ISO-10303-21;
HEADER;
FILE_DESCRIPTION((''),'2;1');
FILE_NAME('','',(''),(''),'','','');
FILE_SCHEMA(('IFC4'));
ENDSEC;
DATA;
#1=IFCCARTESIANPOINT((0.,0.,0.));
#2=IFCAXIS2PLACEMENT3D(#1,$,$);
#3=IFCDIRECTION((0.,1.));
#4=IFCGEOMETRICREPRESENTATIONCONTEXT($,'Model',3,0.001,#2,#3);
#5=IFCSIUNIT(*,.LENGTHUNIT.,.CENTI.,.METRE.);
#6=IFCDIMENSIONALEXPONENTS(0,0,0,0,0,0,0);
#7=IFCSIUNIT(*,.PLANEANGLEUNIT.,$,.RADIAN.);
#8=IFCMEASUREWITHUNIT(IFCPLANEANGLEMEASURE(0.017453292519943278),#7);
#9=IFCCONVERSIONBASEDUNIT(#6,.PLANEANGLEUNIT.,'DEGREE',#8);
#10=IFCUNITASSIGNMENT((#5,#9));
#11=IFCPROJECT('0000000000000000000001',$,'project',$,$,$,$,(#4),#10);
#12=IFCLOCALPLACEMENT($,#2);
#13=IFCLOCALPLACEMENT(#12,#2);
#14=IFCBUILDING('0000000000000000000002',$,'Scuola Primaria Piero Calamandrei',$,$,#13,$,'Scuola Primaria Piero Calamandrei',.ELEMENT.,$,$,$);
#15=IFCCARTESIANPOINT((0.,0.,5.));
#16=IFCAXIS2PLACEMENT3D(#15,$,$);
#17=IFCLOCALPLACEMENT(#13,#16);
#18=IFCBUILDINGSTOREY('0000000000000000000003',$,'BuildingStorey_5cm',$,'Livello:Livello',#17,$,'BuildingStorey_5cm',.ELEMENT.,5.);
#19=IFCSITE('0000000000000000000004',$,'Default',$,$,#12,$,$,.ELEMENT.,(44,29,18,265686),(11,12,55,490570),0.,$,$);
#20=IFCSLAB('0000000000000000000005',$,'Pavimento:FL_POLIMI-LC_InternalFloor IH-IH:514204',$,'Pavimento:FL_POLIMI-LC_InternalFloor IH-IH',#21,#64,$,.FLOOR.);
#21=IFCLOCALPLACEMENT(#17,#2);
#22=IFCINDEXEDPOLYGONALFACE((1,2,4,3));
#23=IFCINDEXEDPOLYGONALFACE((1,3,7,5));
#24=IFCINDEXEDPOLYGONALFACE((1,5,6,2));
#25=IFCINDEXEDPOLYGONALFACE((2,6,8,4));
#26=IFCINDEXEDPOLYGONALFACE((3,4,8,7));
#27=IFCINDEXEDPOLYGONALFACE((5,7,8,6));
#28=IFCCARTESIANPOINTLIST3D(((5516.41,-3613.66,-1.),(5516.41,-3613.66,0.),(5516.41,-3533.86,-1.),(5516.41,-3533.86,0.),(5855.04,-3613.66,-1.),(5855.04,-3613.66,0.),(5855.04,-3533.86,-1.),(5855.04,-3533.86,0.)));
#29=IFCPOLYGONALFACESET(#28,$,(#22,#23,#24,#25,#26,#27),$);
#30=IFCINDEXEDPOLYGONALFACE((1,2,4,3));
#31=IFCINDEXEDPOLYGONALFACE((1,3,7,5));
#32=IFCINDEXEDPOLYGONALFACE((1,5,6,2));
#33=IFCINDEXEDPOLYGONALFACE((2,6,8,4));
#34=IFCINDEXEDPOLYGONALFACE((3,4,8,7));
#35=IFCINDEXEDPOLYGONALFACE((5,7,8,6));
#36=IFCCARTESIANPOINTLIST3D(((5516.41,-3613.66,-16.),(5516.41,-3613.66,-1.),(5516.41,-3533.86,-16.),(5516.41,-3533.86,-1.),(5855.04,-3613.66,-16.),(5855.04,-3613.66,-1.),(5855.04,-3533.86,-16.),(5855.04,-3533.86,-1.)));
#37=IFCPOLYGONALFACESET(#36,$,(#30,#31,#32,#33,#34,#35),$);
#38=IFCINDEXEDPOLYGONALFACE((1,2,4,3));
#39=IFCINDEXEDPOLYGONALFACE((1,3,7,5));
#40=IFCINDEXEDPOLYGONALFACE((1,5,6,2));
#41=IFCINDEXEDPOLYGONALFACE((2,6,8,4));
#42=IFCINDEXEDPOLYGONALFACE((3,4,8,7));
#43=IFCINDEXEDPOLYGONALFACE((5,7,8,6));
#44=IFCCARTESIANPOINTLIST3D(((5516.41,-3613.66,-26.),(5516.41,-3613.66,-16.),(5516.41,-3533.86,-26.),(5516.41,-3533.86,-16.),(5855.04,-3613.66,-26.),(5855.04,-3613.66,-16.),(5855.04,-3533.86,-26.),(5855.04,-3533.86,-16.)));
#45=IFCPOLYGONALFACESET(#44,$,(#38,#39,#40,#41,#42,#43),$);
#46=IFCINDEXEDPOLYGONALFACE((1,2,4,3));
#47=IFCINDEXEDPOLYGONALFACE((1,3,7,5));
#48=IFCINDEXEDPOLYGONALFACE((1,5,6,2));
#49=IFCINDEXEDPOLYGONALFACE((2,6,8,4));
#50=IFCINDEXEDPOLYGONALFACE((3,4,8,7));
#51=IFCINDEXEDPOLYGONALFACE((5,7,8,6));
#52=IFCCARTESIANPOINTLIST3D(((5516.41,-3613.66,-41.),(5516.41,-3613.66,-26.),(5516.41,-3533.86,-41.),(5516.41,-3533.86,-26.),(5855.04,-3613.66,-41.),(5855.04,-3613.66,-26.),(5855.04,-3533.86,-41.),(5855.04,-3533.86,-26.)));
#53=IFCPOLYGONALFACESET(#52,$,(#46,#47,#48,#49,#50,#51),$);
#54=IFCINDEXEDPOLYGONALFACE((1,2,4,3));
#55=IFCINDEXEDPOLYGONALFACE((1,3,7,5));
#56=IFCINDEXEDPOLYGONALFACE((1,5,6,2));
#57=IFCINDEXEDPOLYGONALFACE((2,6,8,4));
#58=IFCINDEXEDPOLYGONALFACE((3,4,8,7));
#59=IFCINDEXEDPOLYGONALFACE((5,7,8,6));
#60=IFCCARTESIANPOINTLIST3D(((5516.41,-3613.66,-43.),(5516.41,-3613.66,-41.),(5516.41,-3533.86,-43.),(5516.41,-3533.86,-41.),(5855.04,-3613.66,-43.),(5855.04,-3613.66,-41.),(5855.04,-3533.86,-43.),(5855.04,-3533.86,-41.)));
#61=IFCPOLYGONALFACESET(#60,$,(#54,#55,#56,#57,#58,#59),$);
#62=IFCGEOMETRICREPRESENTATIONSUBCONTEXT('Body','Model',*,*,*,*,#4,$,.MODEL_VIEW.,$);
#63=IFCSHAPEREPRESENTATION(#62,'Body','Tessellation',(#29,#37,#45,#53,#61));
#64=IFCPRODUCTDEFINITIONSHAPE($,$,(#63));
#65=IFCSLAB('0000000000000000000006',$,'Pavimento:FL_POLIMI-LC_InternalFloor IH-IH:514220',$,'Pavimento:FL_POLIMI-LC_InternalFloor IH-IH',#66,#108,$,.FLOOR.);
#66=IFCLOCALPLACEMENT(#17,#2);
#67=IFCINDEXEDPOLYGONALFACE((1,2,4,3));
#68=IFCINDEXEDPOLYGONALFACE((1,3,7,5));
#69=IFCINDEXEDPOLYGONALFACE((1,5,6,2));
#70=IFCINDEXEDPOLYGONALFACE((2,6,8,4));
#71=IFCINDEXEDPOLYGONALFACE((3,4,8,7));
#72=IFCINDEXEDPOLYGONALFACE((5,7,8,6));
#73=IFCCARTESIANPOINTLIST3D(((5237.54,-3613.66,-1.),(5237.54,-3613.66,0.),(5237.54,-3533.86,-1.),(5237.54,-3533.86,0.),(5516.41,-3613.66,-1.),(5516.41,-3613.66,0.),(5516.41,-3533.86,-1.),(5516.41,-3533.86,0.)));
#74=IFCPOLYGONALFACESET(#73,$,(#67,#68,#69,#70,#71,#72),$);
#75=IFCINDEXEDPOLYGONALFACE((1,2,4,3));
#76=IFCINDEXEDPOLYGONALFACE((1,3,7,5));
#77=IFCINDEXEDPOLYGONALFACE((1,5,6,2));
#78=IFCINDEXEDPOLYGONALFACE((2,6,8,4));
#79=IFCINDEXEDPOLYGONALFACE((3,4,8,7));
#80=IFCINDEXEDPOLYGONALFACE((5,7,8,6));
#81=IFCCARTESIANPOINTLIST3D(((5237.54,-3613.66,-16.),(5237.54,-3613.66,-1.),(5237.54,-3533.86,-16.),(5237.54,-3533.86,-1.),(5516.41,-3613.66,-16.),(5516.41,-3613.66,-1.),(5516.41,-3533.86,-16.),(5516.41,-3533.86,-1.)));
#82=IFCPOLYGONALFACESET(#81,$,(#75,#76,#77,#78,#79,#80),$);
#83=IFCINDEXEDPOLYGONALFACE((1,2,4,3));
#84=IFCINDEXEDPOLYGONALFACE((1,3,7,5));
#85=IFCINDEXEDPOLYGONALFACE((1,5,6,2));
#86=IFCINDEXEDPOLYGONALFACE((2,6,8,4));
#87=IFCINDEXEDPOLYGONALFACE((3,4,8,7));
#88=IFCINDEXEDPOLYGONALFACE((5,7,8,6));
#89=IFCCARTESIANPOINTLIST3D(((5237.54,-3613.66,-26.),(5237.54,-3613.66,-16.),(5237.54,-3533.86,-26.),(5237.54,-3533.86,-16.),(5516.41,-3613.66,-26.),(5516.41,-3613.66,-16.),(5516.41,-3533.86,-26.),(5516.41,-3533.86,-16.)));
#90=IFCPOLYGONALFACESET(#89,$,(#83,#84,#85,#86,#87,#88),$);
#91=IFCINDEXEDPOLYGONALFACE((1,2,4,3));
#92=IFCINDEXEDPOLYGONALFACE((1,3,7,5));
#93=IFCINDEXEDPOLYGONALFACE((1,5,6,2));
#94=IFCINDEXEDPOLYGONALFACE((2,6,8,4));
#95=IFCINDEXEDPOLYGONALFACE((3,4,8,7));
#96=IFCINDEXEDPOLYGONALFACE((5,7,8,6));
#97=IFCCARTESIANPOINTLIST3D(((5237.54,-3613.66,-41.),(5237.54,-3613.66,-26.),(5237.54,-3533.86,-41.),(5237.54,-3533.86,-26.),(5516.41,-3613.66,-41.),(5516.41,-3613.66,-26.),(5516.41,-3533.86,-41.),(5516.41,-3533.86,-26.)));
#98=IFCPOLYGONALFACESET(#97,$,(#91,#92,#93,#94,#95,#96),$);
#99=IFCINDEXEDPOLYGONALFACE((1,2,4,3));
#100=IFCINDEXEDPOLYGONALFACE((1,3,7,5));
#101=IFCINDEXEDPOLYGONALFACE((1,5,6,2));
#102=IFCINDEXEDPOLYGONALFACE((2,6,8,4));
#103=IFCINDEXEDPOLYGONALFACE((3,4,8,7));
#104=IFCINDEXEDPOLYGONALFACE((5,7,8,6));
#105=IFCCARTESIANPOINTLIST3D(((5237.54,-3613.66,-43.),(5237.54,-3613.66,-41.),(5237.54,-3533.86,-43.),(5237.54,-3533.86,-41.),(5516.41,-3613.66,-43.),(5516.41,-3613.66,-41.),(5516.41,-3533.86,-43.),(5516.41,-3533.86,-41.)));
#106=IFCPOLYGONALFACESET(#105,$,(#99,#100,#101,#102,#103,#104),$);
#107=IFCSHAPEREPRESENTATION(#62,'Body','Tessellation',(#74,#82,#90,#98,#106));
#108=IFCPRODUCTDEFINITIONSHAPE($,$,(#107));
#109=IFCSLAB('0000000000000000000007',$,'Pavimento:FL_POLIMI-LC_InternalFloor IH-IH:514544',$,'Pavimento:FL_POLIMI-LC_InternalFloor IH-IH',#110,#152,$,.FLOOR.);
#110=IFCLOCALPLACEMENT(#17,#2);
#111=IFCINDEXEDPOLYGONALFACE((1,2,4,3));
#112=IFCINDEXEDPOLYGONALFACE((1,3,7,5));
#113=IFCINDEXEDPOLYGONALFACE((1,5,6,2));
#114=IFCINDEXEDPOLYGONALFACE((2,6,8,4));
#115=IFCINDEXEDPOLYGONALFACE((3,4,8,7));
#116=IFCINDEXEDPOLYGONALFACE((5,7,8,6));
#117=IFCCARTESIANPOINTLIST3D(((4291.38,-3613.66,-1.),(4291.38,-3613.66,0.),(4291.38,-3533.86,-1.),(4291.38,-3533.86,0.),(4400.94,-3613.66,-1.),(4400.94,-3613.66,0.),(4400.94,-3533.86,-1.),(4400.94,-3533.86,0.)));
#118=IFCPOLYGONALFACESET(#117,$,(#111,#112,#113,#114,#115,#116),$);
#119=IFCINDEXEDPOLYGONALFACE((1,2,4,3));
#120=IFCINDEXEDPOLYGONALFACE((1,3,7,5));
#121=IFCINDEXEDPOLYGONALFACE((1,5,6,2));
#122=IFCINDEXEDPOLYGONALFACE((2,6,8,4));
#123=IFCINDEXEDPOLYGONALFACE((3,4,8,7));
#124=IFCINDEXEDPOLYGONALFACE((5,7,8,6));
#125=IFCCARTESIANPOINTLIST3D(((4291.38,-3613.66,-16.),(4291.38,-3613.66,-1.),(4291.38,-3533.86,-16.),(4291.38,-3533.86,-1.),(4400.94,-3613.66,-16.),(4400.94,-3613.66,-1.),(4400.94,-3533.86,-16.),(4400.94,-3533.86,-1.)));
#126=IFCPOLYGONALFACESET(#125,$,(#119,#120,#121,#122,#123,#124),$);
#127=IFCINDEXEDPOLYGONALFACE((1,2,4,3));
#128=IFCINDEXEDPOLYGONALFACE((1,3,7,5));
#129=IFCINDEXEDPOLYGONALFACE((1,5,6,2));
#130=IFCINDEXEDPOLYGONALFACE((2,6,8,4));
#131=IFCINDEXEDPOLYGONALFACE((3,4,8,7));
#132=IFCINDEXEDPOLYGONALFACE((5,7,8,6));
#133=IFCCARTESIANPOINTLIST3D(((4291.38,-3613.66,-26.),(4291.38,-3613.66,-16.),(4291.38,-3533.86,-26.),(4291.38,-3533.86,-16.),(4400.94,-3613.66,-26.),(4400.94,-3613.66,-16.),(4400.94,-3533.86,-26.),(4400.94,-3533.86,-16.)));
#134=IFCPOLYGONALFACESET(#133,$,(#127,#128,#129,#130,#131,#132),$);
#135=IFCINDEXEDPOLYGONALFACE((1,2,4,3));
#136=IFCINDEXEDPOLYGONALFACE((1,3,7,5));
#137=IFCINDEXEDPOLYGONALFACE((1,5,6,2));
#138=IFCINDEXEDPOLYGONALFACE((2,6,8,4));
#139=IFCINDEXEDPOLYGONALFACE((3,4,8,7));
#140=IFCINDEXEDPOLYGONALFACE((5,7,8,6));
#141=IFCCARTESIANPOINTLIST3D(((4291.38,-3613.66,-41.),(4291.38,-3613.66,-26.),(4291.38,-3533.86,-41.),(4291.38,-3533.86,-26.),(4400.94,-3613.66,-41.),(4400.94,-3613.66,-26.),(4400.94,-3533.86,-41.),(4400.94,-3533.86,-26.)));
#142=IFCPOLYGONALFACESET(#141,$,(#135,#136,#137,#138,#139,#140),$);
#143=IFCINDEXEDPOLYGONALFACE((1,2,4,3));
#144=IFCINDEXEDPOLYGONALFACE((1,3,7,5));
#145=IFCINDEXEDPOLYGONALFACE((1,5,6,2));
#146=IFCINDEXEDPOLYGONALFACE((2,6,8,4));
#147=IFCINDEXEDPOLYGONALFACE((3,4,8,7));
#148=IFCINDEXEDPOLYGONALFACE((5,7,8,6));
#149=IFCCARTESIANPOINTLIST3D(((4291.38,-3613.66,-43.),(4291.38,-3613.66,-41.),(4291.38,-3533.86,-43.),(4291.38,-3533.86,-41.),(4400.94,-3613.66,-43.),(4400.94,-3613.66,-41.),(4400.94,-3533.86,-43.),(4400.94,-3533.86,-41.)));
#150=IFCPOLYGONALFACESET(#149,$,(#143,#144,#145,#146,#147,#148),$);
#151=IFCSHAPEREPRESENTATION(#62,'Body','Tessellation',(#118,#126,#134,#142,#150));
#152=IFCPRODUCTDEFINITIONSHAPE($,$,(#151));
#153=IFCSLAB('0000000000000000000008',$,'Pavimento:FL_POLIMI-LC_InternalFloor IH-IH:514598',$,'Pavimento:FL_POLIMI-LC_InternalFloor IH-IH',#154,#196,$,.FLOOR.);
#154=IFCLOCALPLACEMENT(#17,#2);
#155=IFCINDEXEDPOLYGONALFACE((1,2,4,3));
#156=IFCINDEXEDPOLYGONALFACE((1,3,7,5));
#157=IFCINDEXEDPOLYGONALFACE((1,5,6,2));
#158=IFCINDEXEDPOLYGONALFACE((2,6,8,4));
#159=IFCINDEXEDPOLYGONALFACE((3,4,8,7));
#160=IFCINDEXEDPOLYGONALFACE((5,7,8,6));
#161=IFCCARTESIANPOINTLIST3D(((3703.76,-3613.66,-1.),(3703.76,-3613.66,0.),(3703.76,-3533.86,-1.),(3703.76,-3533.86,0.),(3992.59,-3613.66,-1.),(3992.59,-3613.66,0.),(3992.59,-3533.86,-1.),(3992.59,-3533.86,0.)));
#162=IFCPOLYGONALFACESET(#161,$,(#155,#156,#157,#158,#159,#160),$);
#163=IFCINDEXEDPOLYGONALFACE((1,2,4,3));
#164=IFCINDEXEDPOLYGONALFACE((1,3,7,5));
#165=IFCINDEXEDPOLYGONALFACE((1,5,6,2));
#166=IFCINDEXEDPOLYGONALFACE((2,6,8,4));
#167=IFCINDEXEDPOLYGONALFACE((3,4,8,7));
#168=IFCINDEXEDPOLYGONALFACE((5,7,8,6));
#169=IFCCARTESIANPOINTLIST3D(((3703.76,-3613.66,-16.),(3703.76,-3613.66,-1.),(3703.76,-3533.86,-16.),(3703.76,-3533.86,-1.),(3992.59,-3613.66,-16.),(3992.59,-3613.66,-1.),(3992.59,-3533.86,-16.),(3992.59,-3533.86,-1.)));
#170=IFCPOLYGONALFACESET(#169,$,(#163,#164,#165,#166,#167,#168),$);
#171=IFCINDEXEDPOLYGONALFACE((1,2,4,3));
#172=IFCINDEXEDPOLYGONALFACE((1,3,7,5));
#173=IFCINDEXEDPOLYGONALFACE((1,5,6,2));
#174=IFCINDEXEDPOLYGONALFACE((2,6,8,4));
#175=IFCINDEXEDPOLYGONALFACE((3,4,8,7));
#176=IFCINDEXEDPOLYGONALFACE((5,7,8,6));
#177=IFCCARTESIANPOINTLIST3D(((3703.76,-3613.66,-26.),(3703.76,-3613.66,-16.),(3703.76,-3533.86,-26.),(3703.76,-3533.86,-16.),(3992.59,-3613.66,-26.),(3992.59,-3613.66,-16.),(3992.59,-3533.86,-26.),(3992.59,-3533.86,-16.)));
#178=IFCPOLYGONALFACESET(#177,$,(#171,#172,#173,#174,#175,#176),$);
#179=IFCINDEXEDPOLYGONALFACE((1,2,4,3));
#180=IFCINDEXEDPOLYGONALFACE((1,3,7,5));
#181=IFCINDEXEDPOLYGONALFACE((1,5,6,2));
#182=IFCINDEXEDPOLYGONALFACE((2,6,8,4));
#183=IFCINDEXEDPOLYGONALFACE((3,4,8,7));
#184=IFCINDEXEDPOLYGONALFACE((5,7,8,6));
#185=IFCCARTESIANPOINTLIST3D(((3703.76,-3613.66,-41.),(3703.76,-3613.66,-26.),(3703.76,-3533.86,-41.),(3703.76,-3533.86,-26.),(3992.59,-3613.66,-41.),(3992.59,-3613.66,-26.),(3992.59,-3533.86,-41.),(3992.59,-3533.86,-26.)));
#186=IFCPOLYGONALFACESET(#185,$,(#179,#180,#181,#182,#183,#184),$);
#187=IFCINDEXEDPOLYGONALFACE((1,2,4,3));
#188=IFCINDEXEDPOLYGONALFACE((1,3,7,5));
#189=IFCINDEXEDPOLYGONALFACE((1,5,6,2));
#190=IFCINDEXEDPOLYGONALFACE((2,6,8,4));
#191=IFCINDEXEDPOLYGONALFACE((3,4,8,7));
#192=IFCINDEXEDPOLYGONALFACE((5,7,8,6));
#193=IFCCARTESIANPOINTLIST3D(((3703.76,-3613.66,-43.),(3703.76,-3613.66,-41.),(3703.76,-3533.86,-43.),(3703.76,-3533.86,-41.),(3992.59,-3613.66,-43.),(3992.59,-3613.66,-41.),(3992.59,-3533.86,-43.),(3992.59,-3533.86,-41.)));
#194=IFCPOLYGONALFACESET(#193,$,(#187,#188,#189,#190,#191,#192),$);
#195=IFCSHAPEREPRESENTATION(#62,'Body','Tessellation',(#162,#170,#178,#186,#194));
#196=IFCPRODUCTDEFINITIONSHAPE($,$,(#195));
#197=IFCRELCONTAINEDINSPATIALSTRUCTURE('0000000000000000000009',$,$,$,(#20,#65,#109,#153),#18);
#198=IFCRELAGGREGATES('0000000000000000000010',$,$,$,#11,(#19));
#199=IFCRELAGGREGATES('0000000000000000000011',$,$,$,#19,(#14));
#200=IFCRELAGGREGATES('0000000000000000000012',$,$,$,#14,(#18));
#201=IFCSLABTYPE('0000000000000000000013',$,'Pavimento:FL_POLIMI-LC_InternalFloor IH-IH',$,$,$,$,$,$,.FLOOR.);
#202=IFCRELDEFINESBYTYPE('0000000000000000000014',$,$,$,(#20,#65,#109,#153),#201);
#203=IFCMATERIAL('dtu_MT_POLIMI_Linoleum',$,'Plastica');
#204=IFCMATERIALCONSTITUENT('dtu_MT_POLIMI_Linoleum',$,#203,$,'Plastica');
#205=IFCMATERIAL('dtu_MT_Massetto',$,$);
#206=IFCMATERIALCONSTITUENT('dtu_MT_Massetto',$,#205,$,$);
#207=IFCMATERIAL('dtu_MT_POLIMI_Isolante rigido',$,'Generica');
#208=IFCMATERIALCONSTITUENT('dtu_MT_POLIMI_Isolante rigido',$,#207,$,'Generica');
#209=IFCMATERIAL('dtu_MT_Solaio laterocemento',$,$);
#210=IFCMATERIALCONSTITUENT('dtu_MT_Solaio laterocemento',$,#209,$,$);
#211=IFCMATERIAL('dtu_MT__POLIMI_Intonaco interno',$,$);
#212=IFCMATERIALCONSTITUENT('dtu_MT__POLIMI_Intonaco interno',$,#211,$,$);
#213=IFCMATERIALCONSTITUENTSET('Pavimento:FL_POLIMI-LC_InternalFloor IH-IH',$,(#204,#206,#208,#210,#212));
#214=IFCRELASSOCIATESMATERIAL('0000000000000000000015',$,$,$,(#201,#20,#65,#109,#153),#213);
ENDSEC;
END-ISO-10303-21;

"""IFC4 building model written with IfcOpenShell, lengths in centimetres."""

from ifc_helpers import new_model, entity, si_unit, converted_unit, direction, frame, origin, place, context, subcontext, project, spatial, indexed_curve, outline, extrude, material, constituent, constituent_set, type_object, element, save


model = new_model("IFC4")

# Units and contexts
model_context = context("Model", 3, precision=0.001, world=origin(), true_north=direction((0.0, 1.0)))
body_context = subcontext(model_context, "Body", "Model", "MODEL_VIEW")
ifc_project = project(units=[si_unit("LENGTHUNIT", "METRE", prefix="CENTI"), converted_unit("PLANEANGLEUNIT", "DEGREE", entity("IfcPlaneAngleMeasure", 0.017453292519943278), si_unit("PLANEANGLEUNIT", "RADIAN"), dimensions=[0, 0, 0, 0, 0, 0, 0])], contexts=[model_context])

# Site, building, storey
site_placement = place(None, origin())
site = spatial("IfcSite", under=ifc_project, at=site_placement, Name="Default", CompositionType="ELEMENT", RefLatitude=(44, 29, 18, 265686), RefLongitude=(11, 12, 55, 490570), RefElevation=0.0)
building_placement = place(site_placement, origin())
building = spatial("IfcBuilding", under=site, at=building_placement, Name="Scuola Primaria Piero Calamandrei", LongName="Scuola Primaria Piero Calamandrei", CompositionType="ELEMENT")
storey_placement = place(building_placement, frame((0.0, 0.0, 5.0)))
storey = spatial("IfcBuildingStorey", under=building, at=storey_placement, Name="BuildingStorey_5cm", ObjectType="Livello:Livello", LongName="BuildingStorey_5cm", CompositionType="ELEMENT", Elevation=5.0)

# Slabs
ifc_material_1 = material(Name="dtu_MT_POLIMI_Linoleum", Category="Plastica")
ifc_constituent_1 = constituent(ifc_material_1, Name="dtu_MT_POLIMI_Linoleum", Category="Plastica")
ifc_material_2 = material(Name="dtu_MT_Massetto")
ifc_constituent_2 = constituent(ifc_material_2, Name="dtu_MT_Massetto")
ifc_material_3 = material(Name="dtu_MT_POLIMI_Isolante rigido", Category="Generica")
ifc_constituent_3 = constituent(ifc_material_3, Name="dtu_MT_POLIMI_Isolante rigido", Category="Generica")
ifc_material_4 = material(Name="dtu_MT_Solaio laterocemento")
ifc_constituent_4 = constituent(ifc_material_4, Name="dtu_MT_Solaio laterocemento")
ifc_material_5 = material(Name="dtu_MT__POLIMI_Intonaco interno")
ifc_constituent_5 = constituent(ifc_material_5, Name="dtu_MT__POLIMI_Intonaco interno")
ifc_constituent_set_1 = constituent_set(constituents=[ifc_constituent_1, ifc_constituent_2, ifc_constituent_3, ifc_constituent_4, ifc_constituent_5], Name="Pavimento:FL_POLIMI-LC_InternalFloor IH-IH")
slab_type_1 = type_object("IfcSlabType", Name="Pavimento:FL_POLIMI-LC_InternalFloor IH-IH", PredefinedType="FLOOR", material=ifc_constituent_set_1)
slab_1_placement = place(storey_placement, origin())
element("IfcSlab", 1, at=slab_1_placement, inside=storey, type_object=slab_type_1, material=ifc_constituent_set_1, Name="Pavimento:FL_POLIMI-LC_InternalFloor IH-IH:514204", ObjectType="Pavimento:FL_POLIMI-LC_InternalFloor IH-IH", PredefinedType="FLOOR", context=body_context, shape_type="SweptSolid", body=[
    extrude(outline(indexed_curve([(-39.9, -169.31), (39.9, -169.31), (39.9, 169.31), (-39.9, 169.31), (-39.9, -169.31)], self_intersect=False)), frame((5685.73, -3573.76, -1.0), z_axis=(0.0, 0.0, 1.0), x_axis=(0.0, -1.0, 0.0)), (0.0, 0.0, 1.0), 1.0),
    extrude(outline(indexed_curve([(-39.9, -169.31), (39.9, -169.31), (39.9, 169.31), (-39.9, 169.31), (-39.9, -169.31)], self_intersect=False)), frame((5685.73, -3573.76, -16.0), z_axis=(0.0, 0.0, 1.0), x_axis=(0.0, -1.0, 0.0)), (0.0, 0.0, 1.0), 15.0),
    extrude(outline(indexed_curve([(-39.9, -169.31), (39.9, -169.31), (39.9, 169.31), (-39.9, 169.31), (-39.9, -169.31)], self_intersect=False)), frame((5685.73, -3573.76, -26.0), z_axis=(0.0, 0.0, 1.0), x_axis=(0.0, -1.0, 0.0)), (0.0, 0.0, 1.0), 10.0),
    extrude(outline(indexed_curve([(-39.9, -169.31), (39.9, -169.31), (39.9, 169.31), (-39.9, 169.31), (-39.9, -169.31)], self_intersect=False)), frame((5685.73, -3573.76, -41.0), z_axis=(0.0, 0.0, 1.0), x_axis=(0.0, -1.0, 0.0)), (0.0, 0.0, 1.0), 15.0),
    extrude(outline(indexed_curve([(-39.9, -169.31), (39.9, -169.31), (39.9, 169.31), (-39.9, 169.31), (-39.9, -169.31)], self_intersect=False)), frame((5685.73, -3573.76, -43.0), z_axis=(0.0, 0.0, 1.0), x_axis=(0.0, -1.0, 0.0)), (0.0, 0.0, 1.0), 2.0),
])
slab_2_placement = place(storey_placement, origin())
element("IfcSlab", 2, at=slab_2_placement, inside=storey, type_object=slab_type_1, material=ifc_constituent_set_1, Name="Pavimento:FL_POLIMI-LC_InternalFloor IH-IH:514220", ObjectType="Pavimento:FL_POLIMI-LC_InternalFloor IH-IH", PredefinedType="FLOOR", context=body_context, shape_type="SweptSolid", body=[
    extrude(outline(indexed_curve([(-139.43, -39.9), (139.43, -39.9), (139.43, 39.9), (-139.43, 39.9), (-139.43, -39.9)], self_intersect=False)), frame((5376.98, -3573.76, -1.0), z_axis=(0.0, 0.0, 1.0), x_axis=(-1.0, 0.0, 0.0)), (0.0, 0.0, 1.0), 1.0),
    extrude(outline(indexed_curve([(-139.43, -39.9), (139.43, -39.9), (139.43, 39.9), (-139.43, 39.9), (-139.43, -39.9)], self_intersect=False)), frame((5376.98, -3573.76, -16.0), z_axis=(0.0, 0.0, 1.0), x_axis=(-1.0, 0.0, 0.0)), (0.0, 0.0, 1.0), 15.0),
    extrude(outline(indexed_curve([(-139.43, -39.9), (139.43, -39.9), (139.43, 39.9), (-139.43, 39.9), (-139.43, -39.9)], self_intersect=False)), frame((5376.98, -3573.76, -26.0), z_axis=(0.0, 0.0, 1.0), x_axis=(-1.0, 0.0, 0.0)), (0.0, 0.0, 1.0), 10.0),
    extrude(outline(indexed_curve([(-139.43, -39.9), (139.43, -39.9), (139.43, 39.9), (-139.43, 39.9), (-139.43, -39.9)], self_intersect=False)), frame((5376.98, -3573.76, -41.0), z_axis=(0.0, 0.0, 1.0), x_axis=(-1.0, 0.0, 0.0)), (0.0, 0.0, 1.0), 15.0),
    extrude(outline(indexed_curve([(-139.43, -39.9), (139.43, -39.9), (139.43, 39.9), (-139.43, 39.9), (-139.43, -39.9)], self_intersect=False)), frame((5376.98, -3573.76, -43.0), z_axis=(0.0, 0.0, 1.0), x_axis=(-1.0, 0.0, 0.0)), (0.0, 0.0, 1.0), 2.0),
])
slab_3_placement = place(storey_placement, origin())
element("IfcSlab", 3, at=slab_3_placement, inside=storey, type_object=slab_type_1, material=ifc_constituent_set_1, Name="Pavimento:FL_POLIMI-LC_InternalFloor IH-IH:514544", ObjectType="Pavimento:FL_POLIMI-LC_InternalFloor IH-IH", PredefinedType="FLOOR", context=body_context, shape_type="SweptSolid", body=[
    extrude(outline(indexed_curve([(-39.9, -54.78), (39.9, -54.78), (39.9, 54.78), (-39.9, 54.78), (-39.9, -54.78)], self_intersect=False)), frame((4346.16, -3573.76, -1.0), z_axis=(0.0, 0.0, 1.0), x_axis=(0.0, -1.0, 0.0)), (0.0, 0.0, 1.0), 1.0),
    extrude(outline(indexed_curve([(-39.9, -54.78), (39.9, -54.78), (39.9, 54.78), (-39.9, 54.78), (-39.9, -54.78)], self_intersect=False)), frame((4346.16, -3573.76, -16.0), z_axis=(0.0, 0.0, 1.0), x_axis=(0.0, -1.0, 0.0)), (0.0, 0.0, 1.0), 15.0),
    extrude(outline(indexed_curve([(-39.9, -54.78), (39.9, -54.78), (39.9, 54.78), (-39.9, 54.78), (-39.9, -54.78)], self_intersect=False)), frame((4346.16, -3573.76, -26.0), z_axis=(0.0, 0.0, 1.0), x_axis=(0.0, -1.0, 0.0)), (0.0, 0.0, 1.0), 10.0),
    extrude(outline(indexed_curve([(-39.9, -54.78), (39.9, -54.78), (39.9, 54.78), (-39.9, 54.78), (-39.9, -54.78)], self_intersect=False)), frame((4346.16, -3573.76, -41.0), z_axis=(0.0, 0.0, 1.0), x_axis=(0.0, -1.0, 0.0)), (0.0, 0.0, 1.0), 15.0),
    extrude(outline(indexed_curve([(-39.9, -54.78), (39.9, -54.78), (39.9, 54.78), (-39.9, 54.78), (-39.9, -54.78)], self_intersect=False)), frame((4346.16, -3573.76, -43.0), z_axis=(0.0, 0.0, 1.0), x_axis=(0.0, -1.0, 0.0)), (0.0, 0.0, 1.0), 2.0),
])
slab_4_placement = place(storey_placement, origin())
element("IfcSlab", 4, at=slab_4_placement, inside=storey, type_object=slab_type_1, material=ifc_constituent_set_1, Name="Pavimento:FL_POLIMI-LC_InternalFloor IH-IH:514598", ObjectType="Pavimento:FL_POLIMI-LC_InternalFloor IH-IH", PredefinedType="FLOOR", context=body_context, shape_type="SweptSolid", body=[
    extrude(outline(indexed_curve([(-39.9, -144.41), (39.9, -144.41), (39.9, 144.41), (-39.9, 144.41), (-39.9, -144.41)], self_intersect=False)), frame((3848.18, -3573.76, -1.0), z_axis=(0.0, 0.0, 1.0), x_axis=(0.0, -1.0, 0.0)), (0.0, 0.0, 1.0), 1.0),
    extrude(outline(indexed_curve([(-39.9, -144.41), (39.9, -144.41), (39.9, 144.41), (-39.9, 144.41), (-39.9, -144.41)], self_intersect=False)), frame((3848.18, -3573.76, -16.0), z_axis=(0.0, 0.0, 1.0), x_axis=(0.0, -1.0, 0.0)), (0.0, 0.0, 1.0), 15.0),
    extrude(outline(indexed_curve([(-39.9, -144.41), (39.9, -144.41), (39.9, 144.41), (-39.9, 144.41), (-39.9, -144.41)], self_intersect=False)), frame((3848.18, -3573.76, -26.0), z_axis=(0.0, 0.0, 1.0), x_axis=(0.0, -1.0, 0.0)), (0.0, 0.0, 1.0), 10.0),
    extrude(outline(indexed_curve([(-39.9, -144.41), (39.9, -144.41), (39.9, 144.41), (-39.9, 144.41), (-39.9, -144.41)], self_intersect=False)), frame((3848.18, -3573.76, -41.0), z_axis=(0.0, 0.0, 1.0), x_axis=(0.0, -1.0, 0.0)), (0.0, 0.0, 1.0), 15.0),
    extrude(outline(indexed_curve([(-39.9, -144.41), (39.9, -144.41), (39.9, 144.41), (-39.9, 144.41), (-39.9, -144.41)], self_intersect=False)), frame((3848.18, -3573.76, -43.0), z_axis=(0.0, 0.0, 1.0), x_axis=(0.0, -1.0, 0.0)), (0.0, 0.0, 1.0), 2.0),
])

save(model, "model.ifc")
